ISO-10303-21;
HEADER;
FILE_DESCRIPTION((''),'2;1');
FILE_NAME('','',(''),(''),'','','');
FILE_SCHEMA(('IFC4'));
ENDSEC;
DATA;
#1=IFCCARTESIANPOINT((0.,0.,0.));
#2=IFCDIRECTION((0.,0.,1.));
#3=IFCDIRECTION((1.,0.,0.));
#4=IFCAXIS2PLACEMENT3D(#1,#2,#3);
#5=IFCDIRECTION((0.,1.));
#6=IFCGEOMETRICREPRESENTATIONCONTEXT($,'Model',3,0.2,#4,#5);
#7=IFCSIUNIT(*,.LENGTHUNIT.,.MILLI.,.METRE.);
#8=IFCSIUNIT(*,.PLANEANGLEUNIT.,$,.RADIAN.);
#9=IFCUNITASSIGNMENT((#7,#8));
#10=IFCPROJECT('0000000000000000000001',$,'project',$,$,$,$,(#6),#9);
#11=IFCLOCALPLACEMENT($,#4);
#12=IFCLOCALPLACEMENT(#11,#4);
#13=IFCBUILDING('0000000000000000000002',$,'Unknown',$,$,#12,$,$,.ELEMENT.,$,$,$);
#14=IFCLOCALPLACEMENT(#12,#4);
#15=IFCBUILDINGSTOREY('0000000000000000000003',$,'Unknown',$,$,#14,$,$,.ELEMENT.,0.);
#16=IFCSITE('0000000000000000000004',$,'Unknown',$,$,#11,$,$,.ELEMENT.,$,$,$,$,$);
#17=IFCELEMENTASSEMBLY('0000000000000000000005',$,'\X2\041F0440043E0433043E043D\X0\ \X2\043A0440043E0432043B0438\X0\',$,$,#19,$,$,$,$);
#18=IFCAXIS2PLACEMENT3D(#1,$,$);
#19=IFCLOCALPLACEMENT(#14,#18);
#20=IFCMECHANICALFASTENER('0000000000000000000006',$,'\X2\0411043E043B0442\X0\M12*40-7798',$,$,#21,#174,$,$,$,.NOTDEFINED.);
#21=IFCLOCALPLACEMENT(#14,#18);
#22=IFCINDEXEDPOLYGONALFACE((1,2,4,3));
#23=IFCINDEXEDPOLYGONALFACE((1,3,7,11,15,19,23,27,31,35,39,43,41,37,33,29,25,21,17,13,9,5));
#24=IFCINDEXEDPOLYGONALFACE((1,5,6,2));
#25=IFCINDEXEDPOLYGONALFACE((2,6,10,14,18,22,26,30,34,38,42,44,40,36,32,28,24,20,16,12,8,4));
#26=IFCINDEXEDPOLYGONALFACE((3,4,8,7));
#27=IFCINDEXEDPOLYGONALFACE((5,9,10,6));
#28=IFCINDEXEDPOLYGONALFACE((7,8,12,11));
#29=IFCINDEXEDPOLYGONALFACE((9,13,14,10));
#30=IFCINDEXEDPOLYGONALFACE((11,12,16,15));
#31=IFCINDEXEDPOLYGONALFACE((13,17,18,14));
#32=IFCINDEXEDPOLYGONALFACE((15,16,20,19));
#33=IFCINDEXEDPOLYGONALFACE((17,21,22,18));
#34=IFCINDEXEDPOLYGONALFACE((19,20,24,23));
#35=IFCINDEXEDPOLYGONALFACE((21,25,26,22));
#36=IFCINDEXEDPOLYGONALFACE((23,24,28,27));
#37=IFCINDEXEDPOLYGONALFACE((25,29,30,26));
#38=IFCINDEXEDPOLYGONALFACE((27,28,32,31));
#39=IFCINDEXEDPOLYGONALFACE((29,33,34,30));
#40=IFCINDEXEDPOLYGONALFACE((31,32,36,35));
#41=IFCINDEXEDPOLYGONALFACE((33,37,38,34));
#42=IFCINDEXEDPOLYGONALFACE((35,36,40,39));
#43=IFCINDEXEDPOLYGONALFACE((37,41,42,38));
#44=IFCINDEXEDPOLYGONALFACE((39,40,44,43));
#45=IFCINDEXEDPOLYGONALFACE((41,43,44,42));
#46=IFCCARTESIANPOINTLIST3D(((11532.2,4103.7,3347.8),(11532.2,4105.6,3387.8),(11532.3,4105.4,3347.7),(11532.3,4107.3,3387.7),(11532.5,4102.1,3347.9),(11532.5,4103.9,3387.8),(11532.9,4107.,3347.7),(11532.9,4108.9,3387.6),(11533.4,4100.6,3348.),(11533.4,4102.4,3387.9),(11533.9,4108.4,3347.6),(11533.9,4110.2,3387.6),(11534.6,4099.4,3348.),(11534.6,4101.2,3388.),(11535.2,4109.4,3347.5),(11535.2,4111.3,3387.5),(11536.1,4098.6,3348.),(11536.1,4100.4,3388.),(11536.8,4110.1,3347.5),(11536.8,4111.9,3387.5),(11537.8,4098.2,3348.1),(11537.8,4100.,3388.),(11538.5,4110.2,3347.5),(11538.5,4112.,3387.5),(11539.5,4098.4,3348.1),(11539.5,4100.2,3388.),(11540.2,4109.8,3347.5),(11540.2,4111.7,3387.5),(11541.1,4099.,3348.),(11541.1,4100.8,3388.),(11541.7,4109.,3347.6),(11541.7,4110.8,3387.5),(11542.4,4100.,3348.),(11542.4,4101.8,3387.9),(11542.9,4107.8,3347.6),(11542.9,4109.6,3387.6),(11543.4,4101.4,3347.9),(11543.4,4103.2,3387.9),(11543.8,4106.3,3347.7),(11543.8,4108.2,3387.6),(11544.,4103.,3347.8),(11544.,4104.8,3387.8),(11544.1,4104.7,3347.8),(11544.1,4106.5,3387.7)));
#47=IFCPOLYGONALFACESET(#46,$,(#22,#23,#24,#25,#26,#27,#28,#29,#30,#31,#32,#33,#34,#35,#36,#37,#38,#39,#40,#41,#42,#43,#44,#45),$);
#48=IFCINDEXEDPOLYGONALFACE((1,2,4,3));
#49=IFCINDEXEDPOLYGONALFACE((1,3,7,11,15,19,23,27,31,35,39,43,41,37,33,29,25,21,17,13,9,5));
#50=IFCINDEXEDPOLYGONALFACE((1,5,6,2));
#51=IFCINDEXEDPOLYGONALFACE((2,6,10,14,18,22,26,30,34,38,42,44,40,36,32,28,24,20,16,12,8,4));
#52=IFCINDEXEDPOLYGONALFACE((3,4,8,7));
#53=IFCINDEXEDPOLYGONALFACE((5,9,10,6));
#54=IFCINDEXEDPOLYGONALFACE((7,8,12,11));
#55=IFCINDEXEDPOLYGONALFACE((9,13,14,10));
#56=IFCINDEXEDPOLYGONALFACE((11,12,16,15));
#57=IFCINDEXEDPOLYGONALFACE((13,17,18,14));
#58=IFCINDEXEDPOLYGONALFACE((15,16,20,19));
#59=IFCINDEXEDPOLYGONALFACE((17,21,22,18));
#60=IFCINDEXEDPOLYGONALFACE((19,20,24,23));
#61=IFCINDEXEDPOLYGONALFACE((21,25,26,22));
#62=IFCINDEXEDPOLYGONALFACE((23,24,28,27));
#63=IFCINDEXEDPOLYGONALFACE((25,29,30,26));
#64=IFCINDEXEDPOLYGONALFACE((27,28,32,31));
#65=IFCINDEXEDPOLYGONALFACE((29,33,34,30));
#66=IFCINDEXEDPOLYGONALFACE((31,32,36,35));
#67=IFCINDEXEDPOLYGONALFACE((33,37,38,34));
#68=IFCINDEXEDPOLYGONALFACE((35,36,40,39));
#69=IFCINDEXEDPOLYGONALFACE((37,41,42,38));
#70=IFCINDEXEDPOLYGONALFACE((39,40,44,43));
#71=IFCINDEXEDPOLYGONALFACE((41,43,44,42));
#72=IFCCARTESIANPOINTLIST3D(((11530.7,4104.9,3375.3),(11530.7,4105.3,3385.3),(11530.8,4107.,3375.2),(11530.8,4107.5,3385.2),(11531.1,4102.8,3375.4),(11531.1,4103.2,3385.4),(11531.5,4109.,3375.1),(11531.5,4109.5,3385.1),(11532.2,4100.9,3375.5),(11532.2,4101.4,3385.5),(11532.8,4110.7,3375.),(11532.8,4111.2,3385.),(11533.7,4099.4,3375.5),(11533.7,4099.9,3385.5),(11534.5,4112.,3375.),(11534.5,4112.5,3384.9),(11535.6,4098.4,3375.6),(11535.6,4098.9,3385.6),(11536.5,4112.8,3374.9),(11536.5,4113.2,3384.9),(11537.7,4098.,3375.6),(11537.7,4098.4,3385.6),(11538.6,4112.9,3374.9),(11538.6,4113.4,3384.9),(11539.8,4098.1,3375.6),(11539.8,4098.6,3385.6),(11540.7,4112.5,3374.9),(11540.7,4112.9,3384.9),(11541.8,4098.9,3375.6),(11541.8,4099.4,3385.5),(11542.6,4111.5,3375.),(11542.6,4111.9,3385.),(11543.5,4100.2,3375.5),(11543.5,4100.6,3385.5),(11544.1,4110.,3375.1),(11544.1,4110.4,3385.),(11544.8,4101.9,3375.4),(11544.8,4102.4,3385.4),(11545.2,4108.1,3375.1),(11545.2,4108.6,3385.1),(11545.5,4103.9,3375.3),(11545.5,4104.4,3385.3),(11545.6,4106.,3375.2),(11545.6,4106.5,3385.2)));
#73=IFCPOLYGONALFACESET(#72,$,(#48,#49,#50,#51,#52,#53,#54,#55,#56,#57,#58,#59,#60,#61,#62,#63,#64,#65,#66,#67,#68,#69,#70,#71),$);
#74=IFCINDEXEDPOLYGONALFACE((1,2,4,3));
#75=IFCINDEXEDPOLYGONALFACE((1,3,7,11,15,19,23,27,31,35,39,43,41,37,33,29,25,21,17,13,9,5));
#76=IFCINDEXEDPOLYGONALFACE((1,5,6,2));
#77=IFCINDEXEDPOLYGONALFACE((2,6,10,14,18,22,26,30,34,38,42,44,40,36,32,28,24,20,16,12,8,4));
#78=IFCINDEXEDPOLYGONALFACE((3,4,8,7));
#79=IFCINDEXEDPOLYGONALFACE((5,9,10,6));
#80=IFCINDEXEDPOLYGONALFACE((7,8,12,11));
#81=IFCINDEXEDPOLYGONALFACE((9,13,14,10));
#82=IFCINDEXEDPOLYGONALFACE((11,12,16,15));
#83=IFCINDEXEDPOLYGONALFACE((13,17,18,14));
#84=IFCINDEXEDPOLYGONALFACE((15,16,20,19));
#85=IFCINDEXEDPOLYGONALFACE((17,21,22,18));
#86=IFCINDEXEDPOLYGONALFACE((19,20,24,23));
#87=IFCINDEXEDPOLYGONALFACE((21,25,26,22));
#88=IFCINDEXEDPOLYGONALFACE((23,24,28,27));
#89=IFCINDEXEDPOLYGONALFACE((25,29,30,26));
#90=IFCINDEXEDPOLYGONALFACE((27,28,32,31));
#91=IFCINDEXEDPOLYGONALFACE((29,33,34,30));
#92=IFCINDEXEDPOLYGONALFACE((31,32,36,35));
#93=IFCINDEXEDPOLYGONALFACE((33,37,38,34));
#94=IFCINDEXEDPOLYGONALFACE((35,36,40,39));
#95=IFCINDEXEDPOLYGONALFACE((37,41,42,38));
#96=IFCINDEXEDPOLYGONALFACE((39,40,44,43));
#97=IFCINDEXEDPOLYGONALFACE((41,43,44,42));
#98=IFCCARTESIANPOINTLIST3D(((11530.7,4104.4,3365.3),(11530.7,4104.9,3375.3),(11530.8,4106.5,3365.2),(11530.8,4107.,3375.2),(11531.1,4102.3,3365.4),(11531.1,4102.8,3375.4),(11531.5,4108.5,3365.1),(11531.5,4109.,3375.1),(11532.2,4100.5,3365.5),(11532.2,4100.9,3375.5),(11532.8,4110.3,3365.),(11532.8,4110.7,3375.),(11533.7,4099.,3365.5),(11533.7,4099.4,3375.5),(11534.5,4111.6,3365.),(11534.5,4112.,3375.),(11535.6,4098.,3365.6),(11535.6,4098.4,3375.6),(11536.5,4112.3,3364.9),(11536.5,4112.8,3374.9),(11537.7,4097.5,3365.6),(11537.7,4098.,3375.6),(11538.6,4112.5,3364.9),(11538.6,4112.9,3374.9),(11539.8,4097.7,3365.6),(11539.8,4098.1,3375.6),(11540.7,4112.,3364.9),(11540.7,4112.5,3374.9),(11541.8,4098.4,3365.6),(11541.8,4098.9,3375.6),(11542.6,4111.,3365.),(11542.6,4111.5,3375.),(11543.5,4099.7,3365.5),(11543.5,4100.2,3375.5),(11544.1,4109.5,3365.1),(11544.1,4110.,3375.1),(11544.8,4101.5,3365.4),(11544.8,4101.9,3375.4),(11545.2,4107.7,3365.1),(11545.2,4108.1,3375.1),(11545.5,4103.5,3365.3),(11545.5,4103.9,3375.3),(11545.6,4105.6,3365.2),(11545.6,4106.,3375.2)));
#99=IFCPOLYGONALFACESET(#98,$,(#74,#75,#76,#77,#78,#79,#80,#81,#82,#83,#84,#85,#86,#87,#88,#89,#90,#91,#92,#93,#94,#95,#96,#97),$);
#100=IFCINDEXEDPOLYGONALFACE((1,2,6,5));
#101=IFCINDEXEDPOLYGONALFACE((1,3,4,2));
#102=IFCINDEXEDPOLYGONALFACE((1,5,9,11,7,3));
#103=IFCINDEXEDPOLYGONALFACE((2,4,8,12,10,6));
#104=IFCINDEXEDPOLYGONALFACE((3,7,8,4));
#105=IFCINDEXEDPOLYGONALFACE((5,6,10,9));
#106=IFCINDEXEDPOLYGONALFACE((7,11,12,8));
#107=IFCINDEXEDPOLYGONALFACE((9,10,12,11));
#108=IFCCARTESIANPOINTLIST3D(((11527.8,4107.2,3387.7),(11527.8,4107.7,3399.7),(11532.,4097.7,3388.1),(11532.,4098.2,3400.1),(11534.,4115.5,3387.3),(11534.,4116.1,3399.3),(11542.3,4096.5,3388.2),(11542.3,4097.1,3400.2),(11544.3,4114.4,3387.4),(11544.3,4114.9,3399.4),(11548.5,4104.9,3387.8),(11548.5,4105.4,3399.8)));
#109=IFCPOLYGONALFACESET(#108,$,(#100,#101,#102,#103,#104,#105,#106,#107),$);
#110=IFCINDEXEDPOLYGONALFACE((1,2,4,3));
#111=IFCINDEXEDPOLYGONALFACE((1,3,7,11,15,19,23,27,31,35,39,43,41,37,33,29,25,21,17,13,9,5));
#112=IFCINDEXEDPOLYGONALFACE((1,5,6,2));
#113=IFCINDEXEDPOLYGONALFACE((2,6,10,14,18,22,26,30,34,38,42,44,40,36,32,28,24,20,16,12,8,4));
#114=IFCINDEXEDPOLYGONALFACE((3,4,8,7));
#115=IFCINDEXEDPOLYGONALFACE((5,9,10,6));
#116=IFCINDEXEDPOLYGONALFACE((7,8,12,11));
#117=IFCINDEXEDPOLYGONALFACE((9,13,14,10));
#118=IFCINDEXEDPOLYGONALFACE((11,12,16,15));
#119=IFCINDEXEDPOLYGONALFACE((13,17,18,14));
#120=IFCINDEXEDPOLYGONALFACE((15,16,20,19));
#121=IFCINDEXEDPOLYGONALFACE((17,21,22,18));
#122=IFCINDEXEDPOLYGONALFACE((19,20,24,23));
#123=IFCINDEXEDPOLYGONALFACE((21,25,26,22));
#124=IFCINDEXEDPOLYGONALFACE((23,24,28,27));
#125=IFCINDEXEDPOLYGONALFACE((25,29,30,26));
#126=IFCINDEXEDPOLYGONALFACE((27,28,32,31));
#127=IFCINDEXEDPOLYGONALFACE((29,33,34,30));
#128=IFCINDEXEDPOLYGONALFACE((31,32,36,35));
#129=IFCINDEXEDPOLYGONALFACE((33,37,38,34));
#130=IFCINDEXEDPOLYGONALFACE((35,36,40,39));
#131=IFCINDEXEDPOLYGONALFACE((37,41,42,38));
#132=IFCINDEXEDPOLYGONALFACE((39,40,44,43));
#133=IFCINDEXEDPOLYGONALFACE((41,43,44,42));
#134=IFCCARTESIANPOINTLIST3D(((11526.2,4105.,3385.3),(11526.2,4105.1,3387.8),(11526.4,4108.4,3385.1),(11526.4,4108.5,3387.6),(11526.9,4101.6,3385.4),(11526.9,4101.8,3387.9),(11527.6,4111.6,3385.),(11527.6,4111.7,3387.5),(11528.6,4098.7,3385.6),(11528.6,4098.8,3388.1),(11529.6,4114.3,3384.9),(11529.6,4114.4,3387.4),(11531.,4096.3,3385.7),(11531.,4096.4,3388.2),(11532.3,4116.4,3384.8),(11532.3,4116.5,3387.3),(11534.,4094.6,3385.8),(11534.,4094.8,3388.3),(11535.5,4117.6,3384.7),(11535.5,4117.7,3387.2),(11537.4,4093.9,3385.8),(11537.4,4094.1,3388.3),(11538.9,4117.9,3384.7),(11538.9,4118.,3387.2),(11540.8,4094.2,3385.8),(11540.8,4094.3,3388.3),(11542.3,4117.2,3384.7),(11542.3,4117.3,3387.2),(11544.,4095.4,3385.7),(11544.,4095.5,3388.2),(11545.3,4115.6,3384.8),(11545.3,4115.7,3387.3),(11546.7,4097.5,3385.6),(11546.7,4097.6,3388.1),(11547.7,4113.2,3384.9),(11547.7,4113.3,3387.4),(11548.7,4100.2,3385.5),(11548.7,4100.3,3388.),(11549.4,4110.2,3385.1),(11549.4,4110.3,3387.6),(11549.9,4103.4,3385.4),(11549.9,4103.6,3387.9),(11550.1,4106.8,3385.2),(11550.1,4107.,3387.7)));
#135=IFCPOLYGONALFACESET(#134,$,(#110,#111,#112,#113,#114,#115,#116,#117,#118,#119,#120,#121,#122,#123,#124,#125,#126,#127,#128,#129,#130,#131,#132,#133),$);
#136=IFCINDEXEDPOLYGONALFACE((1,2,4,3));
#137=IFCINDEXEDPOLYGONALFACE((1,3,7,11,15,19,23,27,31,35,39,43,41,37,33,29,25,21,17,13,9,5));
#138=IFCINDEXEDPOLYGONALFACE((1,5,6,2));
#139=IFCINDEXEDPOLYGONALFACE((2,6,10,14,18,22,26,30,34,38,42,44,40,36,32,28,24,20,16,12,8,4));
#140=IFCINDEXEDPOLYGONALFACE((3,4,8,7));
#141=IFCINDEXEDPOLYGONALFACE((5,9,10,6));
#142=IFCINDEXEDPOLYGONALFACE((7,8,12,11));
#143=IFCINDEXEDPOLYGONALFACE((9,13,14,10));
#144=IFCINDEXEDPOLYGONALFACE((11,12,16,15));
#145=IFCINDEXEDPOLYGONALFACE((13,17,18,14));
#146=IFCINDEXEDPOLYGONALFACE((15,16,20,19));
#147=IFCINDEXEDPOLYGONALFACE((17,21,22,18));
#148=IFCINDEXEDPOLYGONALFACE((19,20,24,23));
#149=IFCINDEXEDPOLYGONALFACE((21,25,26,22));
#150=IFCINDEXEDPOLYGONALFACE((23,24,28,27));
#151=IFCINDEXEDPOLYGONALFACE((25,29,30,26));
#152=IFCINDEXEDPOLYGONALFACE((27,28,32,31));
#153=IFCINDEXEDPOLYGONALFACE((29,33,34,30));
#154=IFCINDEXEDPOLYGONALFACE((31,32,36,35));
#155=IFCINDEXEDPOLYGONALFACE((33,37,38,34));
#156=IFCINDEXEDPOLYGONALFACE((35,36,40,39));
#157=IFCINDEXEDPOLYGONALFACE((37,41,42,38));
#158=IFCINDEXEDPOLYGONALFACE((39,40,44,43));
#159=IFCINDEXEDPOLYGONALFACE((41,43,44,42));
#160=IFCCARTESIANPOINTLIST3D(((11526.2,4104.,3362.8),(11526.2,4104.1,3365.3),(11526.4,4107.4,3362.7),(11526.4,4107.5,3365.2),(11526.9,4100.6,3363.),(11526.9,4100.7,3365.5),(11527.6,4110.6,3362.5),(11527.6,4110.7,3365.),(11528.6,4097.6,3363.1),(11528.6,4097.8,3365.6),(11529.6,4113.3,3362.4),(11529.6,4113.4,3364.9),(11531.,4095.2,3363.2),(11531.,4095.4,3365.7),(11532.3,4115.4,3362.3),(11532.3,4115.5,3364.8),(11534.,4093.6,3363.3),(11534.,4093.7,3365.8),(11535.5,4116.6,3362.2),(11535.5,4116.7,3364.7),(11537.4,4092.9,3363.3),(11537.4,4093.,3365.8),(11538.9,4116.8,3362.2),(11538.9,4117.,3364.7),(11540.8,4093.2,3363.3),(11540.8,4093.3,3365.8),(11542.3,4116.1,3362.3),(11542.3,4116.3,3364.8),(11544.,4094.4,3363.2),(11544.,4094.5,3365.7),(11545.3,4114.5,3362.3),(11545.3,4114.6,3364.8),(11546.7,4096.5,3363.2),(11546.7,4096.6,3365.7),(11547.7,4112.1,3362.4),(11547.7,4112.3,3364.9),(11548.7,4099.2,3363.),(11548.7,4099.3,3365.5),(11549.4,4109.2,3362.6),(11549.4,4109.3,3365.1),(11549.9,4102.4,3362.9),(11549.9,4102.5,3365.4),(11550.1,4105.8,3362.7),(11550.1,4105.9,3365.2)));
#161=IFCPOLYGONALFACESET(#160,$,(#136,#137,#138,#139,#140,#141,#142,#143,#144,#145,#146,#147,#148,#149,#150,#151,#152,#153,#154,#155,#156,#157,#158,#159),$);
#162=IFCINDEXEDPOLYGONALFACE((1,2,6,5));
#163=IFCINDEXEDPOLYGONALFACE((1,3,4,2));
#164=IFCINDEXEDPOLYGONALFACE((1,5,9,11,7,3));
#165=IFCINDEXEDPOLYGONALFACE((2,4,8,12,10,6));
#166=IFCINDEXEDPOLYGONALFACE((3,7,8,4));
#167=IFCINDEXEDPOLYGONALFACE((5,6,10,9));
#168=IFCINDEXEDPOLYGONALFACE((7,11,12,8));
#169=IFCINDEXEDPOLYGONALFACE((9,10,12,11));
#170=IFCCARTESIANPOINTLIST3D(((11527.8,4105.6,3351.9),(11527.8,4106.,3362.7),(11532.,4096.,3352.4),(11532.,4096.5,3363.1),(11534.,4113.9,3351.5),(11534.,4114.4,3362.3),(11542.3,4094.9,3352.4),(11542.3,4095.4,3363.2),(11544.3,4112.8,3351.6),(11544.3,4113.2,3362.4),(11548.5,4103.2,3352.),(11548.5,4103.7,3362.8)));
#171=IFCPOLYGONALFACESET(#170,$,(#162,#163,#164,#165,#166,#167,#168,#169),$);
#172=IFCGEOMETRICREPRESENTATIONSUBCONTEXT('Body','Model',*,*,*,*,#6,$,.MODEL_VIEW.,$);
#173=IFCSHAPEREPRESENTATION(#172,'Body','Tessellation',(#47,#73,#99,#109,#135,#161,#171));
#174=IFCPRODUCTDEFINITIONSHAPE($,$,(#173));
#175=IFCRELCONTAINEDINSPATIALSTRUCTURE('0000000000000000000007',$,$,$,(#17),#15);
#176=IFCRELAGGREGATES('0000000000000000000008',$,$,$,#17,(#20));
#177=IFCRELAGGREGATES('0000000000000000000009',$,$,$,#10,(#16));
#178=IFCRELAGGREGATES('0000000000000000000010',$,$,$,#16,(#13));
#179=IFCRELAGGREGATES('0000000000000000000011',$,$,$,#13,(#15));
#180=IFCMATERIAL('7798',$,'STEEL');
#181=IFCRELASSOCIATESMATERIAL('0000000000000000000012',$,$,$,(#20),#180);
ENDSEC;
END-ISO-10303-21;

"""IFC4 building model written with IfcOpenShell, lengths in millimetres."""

from ifc_helpers import new_model, si_unit, direction, frame, origin_with_axes, place, context, subcontext, project, spatial, line, arc, indexed_curve, outline, extrude, source, transform, mapped, material, element, aggregate, save


model = new_model("IFC4")

# Units and contexts
model_context = context("Model", 3, precision=0.2, world=origin_with_axes(), true_north=direction((0.0, 1.0)))
body_context = subcontext(model_context, "Body", "Model", "MODEL_VIEW")
ifc_project = project(units=[si_unit("LENGTHUNIT", "METRE", prefix="MILLI"), si_unit("PLANEANGLEUNIT", "RADIAN")], contexts=[model_context])

# Site, building, storey
site_placement = place(None, origin_with_axes())
site = spatial("IfcSite", under=ifc_project, at=site_placement, Name="Unknown", CompositionType="ELEMENT")
building_placement = place(site_placement, origin_with_axes())
building = spatial("IfcBuilding", under=site, at=building_placement, Name="Unknown", CompositionType="ELEMENT")
storey_placement = place(building_placement, origin_with_axes())
storey = spatial("IfcBuildingStorey", under=building, at=storey_placement, Name="Unknown", CompositionType="ELEMENT", Elevation=0.0)

# Element assembly
assembly_1_placement = place(storey_placement, frame((17395.0, 4207.1, 3365.6), z_axis=(0.0, 0.998969, -0.045408), x_axis=(-1.0, 0.0, 0.0)))
assembly_1 = element("IfcElementAssembly", 1, at=assembly_1_placement, inside=storey, Name="Прогон кровли")

# Mechanical fastener
ifc_material_1 = material(Name="7798", Category="STEEL")
shared_shape_1 = source(origin_with_axes(), body_context, "Body", "SweptSolid", [
    extrude(outline(indexed_curve([(6.0, 0.0), (0.0, 6.0), (-6.0, 0.0), (0.0, -6.0)], segments=[arc(1, 2, 3), arc(3, 4, 1)])), frame((0.0, 0.0, 12.5), z_axis=(0.0, 0.0, -1.0), x_axis=(0.0, 1.0, 0.0)), (0.0, 0.0, 1.0), 40.0),
    extrude(outline(indexed_curve([(7.5, 0.0), (0.0, 7.5), (-7.5, 0.0), (0.0, -7.5)], segments=[arc(1, 2, 3), arc(3, 4, 1)])), frame((0.0, 0.0, 10.0), z_axis=(0.0, 0.0, -1.0), x_axis=(0.0, 1.0, 0.0)), (0.0, 0.0, 1.0), 10.0),
    extrude(outline(indexed_curve([(7.5, 0.0), (0.0, 7.5), (-7.5, 0.0), (0.0, -7.5)], segments=[arc(1, 2, 3), arc(3, 4, 1)])), frame((0.0, 0.0, 0.0), z_axis=(0.0, 0.0, -1.0), x_axis=(0.0, 1.0, 0.0)), (0.0, 0.0, 1.0), 10.0),
    extrude(outline(indexed_curve([(10.4, 0.0), (5.2, 9.0), (-5.2, 9.0), (-10.4, 0.0), (-5.2, -9.0), (5.2, -9.0)], segments=[line(1, 2, 3, 4, 5, 6, 1)])), frame((0.0, 0.0, 24.5), z_axis=(0.0, 0.0, -1.0), x_axis=(0.0, 1.0, 0.0)), (0.0, 0.0, 1.0), 12.0),
    extrude(outline(indexed_curve([(12.0, 0.0), (0.0, 12.0), (-12.0, 0.0), (0.0, -12.0)], segments=[arc(1, 2, 3), arc(3, 4, 1)])), frame((0.0, 0.0, 12.5), z_axis=(0.0, 0.0, -1.0), x_axis=(0.0, 1.0, 0.0)), (0.0, 0.0, 1.0), 2.5),
    extrude(outline(indexed_curve([(12.0, 0.0), (0.0, 12.0), (-12.0, 0.0), (0.0, -12.0)], segments=[arc(1, 2, 3), arc(3, 4, 1)])), frame((0.0, 0.0, -10.0), z_axis=(0.0, 0.0, -1.0), x_axis=(0.0, 1.0, 0.0)), (0.0, 0.0, 1.0), 2.5),
    extrude(outline(indexed_curve([(10.4, 0.0), (5.2, 9.0), (-5.2, 9.0), (-10.4, 0.0), (-5.2, -9.0), (5.2, -9.0)], segments=[line(1, 2, 3, 4, 5, 6, 1)])), frame((0.0, 0.0, -12.5), z_axis=(0.0, 0.0, -1.0), x_axis=(0.0, 1.0, 0.0)), (0.0, 0.0, 1.0), 10.8),
])
mechanical_fastener_1_placement = place(assembly_1_placement, frame((5856.9, 5.0, -102.0), z_axis=(0.0, 1.0, 0.0), x_axis=(-0.804616, 0.0, -0.593795)))
mechanical_fastener_1 = element("IfcMechanicalFastener", 2, at=mechanical_fastener_1_placement, material=ifc_material_1, Name="БолтM12*40-7798", PredefinedType="NOTDEFINED", context=body_context, shape_type="MappedRepresentation", body=[
    mapped(shared_shape_1, transform((0.0, 0.0, 0.0))),
])
aggregate(assembly_1, [mechanical_fastener_1])

save(model, "model.ifc")
